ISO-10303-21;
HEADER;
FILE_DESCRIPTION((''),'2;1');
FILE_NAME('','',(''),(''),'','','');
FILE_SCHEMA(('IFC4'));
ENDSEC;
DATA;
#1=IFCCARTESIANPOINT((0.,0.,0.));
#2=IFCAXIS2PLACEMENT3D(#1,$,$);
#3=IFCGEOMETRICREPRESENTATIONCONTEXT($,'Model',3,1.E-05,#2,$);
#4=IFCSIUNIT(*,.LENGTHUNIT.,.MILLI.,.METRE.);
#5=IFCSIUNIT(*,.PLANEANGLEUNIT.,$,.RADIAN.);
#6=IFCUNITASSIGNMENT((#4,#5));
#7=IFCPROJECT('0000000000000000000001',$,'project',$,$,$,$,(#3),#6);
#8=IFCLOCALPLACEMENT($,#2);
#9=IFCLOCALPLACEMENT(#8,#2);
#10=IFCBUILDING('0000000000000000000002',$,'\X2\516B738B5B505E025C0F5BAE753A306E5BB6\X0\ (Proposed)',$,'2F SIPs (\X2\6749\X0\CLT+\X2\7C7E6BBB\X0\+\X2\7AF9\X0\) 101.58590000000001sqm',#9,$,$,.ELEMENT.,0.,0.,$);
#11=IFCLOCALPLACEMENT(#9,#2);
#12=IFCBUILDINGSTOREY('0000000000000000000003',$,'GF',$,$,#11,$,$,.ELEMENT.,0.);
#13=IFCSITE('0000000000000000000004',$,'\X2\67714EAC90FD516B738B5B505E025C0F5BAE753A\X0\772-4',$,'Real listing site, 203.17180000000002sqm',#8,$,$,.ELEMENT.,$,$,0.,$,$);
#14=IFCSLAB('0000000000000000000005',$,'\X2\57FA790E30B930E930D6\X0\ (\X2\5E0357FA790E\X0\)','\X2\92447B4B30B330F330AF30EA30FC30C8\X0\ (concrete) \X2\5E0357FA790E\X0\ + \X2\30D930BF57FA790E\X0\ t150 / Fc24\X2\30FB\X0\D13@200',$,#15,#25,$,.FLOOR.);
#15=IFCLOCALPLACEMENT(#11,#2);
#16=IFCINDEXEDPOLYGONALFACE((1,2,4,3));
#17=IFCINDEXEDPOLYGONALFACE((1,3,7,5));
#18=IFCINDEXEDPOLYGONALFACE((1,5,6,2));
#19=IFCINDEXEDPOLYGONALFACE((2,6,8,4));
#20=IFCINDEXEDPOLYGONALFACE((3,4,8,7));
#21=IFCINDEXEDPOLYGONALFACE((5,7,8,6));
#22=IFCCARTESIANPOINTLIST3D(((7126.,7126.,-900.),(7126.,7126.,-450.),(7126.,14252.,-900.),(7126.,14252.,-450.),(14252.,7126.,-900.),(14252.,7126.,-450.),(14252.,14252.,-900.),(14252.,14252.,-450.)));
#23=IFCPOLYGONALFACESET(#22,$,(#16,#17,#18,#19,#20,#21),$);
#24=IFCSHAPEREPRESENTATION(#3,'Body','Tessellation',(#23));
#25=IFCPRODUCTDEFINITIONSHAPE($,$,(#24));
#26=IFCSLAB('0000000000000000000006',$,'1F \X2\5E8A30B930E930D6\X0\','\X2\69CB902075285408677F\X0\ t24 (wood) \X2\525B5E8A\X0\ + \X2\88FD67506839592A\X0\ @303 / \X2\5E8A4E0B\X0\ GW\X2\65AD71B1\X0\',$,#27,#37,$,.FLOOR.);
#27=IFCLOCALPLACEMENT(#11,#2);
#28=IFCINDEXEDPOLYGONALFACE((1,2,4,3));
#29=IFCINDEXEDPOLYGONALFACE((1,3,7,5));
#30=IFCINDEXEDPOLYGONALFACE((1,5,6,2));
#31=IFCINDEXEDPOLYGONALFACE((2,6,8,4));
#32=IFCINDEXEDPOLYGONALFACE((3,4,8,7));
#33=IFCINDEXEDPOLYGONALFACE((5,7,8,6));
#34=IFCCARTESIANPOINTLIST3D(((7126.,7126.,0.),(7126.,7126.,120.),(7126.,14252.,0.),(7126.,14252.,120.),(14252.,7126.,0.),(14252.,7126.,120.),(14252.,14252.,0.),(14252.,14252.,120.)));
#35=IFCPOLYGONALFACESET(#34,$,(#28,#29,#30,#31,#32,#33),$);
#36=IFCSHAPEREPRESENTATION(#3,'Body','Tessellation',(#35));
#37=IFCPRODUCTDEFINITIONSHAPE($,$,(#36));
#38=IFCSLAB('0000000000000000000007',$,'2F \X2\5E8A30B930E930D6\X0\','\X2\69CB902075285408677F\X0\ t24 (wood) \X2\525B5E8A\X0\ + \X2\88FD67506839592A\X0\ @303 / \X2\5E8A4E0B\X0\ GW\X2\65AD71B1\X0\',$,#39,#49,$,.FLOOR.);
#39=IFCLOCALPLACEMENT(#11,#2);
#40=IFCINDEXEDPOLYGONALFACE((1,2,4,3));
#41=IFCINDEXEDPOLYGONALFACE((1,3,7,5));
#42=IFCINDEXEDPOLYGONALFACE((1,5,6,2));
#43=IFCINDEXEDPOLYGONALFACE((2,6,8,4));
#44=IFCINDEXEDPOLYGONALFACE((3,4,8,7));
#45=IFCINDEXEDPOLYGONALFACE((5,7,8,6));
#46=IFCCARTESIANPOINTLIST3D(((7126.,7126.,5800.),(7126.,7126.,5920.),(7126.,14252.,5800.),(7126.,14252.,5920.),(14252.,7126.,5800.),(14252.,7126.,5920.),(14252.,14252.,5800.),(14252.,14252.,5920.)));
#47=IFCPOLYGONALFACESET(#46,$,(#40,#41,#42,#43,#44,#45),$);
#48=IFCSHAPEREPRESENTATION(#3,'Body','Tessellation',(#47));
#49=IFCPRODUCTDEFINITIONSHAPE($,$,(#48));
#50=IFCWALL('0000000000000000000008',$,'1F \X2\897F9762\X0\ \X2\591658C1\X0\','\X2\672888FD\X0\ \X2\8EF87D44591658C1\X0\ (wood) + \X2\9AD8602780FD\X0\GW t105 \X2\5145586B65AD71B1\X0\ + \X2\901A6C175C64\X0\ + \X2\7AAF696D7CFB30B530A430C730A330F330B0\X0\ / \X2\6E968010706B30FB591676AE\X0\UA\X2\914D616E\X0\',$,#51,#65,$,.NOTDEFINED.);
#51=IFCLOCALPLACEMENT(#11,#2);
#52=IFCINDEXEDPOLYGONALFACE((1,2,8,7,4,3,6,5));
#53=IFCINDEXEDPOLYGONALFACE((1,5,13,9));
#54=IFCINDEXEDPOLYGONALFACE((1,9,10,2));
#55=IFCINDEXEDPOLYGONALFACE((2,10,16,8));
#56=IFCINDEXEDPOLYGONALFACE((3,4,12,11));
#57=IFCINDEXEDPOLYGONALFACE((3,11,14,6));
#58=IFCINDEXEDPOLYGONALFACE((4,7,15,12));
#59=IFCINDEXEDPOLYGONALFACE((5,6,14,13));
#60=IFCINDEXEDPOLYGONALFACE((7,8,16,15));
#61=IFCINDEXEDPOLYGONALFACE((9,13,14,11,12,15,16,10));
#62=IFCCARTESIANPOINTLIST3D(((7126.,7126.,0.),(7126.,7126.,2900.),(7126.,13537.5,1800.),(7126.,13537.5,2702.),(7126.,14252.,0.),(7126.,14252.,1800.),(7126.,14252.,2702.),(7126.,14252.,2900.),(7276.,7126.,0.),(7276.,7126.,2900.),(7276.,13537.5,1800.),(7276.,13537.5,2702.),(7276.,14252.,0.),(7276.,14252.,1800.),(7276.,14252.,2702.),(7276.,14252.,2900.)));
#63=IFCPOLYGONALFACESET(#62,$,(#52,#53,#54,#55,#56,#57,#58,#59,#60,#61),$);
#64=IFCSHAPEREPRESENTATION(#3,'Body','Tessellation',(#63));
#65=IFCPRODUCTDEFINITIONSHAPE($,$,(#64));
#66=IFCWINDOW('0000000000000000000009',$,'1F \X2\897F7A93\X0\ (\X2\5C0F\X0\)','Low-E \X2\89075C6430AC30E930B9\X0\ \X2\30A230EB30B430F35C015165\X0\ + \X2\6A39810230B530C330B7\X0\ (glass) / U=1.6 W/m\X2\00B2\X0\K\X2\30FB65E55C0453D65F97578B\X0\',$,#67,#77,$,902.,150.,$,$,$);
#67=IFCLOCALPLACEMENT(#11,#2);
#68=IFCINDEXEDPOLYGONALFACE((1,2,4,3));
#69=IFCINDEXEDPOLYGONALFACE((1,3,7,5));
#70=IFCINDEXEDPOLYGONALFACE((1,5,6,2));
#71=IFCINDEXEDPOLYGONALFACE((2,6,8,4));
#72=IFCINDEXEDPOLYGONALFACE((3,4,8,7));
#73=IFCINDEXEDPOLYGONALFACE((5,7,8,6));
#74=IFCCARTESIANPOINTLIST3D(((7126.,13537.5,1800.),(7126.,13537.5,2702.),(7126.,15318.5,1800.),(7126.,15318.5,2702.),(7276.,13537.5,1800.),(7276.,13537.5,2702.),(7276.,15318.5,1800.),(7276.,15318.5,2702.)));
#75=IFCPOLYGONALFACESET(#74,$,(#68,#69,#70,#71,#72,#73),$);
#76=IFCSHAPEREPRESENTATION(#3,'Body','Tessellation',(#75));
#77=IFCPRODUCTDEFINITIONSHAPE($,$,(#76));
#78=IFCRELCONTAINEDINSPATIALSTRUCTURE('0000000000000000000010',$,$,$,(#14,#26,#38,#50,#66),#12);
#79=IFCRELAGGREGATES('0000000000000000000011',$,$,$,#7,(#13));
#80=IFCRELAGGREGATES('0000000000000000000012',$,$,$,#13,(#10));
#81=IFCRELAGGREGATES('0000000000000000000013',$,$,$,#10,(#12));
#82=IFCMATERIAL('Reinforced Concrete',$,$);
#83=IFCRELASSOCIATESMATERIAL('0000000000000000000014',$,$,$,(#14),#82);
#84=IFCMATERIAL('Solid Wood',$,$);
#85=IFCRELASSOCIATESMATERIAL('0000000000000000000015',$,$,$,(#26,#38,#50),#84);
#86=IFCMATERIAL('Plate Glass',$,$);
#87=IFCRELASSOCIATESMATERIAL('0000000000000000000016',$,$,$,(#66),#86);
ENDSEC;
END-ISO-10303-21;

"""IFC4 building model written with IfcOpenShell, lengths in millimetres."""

from ifc_helpers import new_model, si_unit, frame, frame_2d, origin, place, context, project, spatial, rectangle, extrude, material, element, fill, save


model = new_model("IFC4")

# Units and contexts
model_context = context("Model", 3, precision=1e-05, world=origin())
ifc_project = project(units=[si_unit("LENGTHUNIT", "METRE", prefix="MILLI"), si_unit("PLANEANGLEUNIT", "RADIAN")], contexts=[model_context])

# Site, building, storey
site_placement = place(None, origin())
site = spatial("IfcSite", under=ifc_project, at=site_placement, Name="東京都八王子市小宮町772-4", ObjectType="Real listing site, 203.17180000000002sqm", CompositionType="ELEMENT", RefElevation=0.0)
building_placement = place(site_placement, origin())
building = spatial("IfcBuilding", under=site, at=building_placement, Name="八王子市小宮町の家 (Proposed)", ObjectType="2F SIPs (杉CLT+籾殻+竹) 101.58590000000001sqm", CompositionType="ELEMENT", ElevationOfRefHeight=0.0, ElevationOfTerrain=0.0)
storey_placement = place(building_placement, origin())
storey = spatial("IfcBuildingStorey", under=building, at=storey_placement, Name="GF", CompositionType="ELEMENT", Elevation=0.0)

# Slabs
ifc_material_1 = material(Name="Reinforced Concrete")
slab_1_placement = place(storey_placement, frame((3563.0, 3563.0, -450.0)))
element("IfcSlab", 1, at=slab_1_placement, inside=storey, material=ifc_material_1, Name="基礎スラブ (布基礎)", Description="鉄筋コンクリート (concrete) 布基礎 + ベタ基礎 t150 / Fc24・D13@200", PredefinedType="FLOOR", context=model_context, shape_type="SweptSolid", body=[
    extrude(rectangle(XDim=7126.0, YDim=7126.0, at=frame_2d((3563.0, 3563.0))), frame((3563.0, 3563.0, -450.0)), (0.0, 0.0, 1.0), 450.0),
])
ifc_material_2 = material(Name="Solid Wood")
slab_2_placement = place(storey_placement, frame((3563.0, 3563.0, 0.0)))
element("IfcSlab", 2, at=slab_2_placement, inside=storey, material=ifc_material_2, Name="1F 床スラブ", Description="構造用合板 t24 (wood) 剛床 + 製材根太 @303 / 床下 GW断熱", PredefinedType="FLOOR", context=model_context, shape_type="SweptSolid", body=[
    extrude(rectangle(XDim=7126.0, YDim=7126.0, at=frame_2d((3563.0, 3563.0))), frame((3563.0, 3563.0, 0.0)), (0.0, 0.0, 1.0), 120.0),
])
slab_3_placement = place(storey_placement, frame((3563.0, 3563.0, 2900.0)))
element("IfcSlab", 3, at=slab_3_placement, inside=storey, material=ifc_material_2, Name="2F 床スラブ", Description="構造用合板 t24 (wood) 剛床 + 製材根太 @303 / 床下 GW断熱", PredefinedType="FLOOR", context=model_context, shape_type="SweptSolid", body=[
    extrude(rectangle(XDim=7126.0, YDim=7126.0, at=frame_2d((3563.0, 3563.0))), frame((3563.0, 3563.0, 2900.0)), (0.0, 0.0, 1.0), 120.0),
])

# Shared definitions
ifc_material_3 = material(Name="Plate Glass")

# Wall, opening, window
wall_1_placement = place(storey_placement, frame((3563.0, 3563.0, 0.0)))
wall_1 = element("IfcWall", 4, at=wall_1_placement, inside=storey, material=ifc_material_2, Name="1F 西面 外壁", Description="木製 軸組外壁 (wood) + 高性能GW t105 充填断熱 + 通気層 + 窯業系サイディング / 準耐火・外皮UA配慮", PredefinedType="NOTDEFINED", context=model_context, shape_type="SweptSolid", body=[
    extrude(rectangle(XDim=150.0, YDim=7126.0, at=frame_2d((75.0, 3563.0))), frame((3563.0, 3563.0, 0.0)), (0.0, 0.0, 1.0), 2900.0),
])
opening_1_placement = place(storey_placement, frame((3563.0, 6769.0, 900.0)))
opening_1 = element("IfcOpeningElement", 5, at=opening_1_placement, cuts=wall_1, PredefinedType="NOTDEFINED", context=model_context, shape_type="SweptSolid", body=[
    extrude(rectangle(XDim=150.0, YDim=1781.0, at=frame_2d((75.0, 890.0))), frame((3563.0, 6769.0, 900.0)), (0.0, 0.0, 1.0), 902.0),
])
window_1_placement = place(storey_placement, frame((3563.0, 6769.0, 900.0)))
window_1 = element("IfcWindow", 6, at=window_1_placement, inside=storey, material=ifc_material_3, Name="1F 西窓 (小)", Description="Low-E 複層ガラス アルゴン封入 + 樹脂サッシ (glass) / U=1.6 W/m²K・日射取得型", OverallHeight=902.0, OverallWidth=150.0, context=model_context, shape_type="SweptSolid", body=[
    extrude(rectangle(XDim=150.0, YDim=1781.0, at=frame_2d((75.0, 890.0))), frame((3563.0, 6769.0, 900.0)), (0.0, 0.0, 1.0), 902.0),
])
fill(opening_1, window_1)

save(model, "model.ifc")
